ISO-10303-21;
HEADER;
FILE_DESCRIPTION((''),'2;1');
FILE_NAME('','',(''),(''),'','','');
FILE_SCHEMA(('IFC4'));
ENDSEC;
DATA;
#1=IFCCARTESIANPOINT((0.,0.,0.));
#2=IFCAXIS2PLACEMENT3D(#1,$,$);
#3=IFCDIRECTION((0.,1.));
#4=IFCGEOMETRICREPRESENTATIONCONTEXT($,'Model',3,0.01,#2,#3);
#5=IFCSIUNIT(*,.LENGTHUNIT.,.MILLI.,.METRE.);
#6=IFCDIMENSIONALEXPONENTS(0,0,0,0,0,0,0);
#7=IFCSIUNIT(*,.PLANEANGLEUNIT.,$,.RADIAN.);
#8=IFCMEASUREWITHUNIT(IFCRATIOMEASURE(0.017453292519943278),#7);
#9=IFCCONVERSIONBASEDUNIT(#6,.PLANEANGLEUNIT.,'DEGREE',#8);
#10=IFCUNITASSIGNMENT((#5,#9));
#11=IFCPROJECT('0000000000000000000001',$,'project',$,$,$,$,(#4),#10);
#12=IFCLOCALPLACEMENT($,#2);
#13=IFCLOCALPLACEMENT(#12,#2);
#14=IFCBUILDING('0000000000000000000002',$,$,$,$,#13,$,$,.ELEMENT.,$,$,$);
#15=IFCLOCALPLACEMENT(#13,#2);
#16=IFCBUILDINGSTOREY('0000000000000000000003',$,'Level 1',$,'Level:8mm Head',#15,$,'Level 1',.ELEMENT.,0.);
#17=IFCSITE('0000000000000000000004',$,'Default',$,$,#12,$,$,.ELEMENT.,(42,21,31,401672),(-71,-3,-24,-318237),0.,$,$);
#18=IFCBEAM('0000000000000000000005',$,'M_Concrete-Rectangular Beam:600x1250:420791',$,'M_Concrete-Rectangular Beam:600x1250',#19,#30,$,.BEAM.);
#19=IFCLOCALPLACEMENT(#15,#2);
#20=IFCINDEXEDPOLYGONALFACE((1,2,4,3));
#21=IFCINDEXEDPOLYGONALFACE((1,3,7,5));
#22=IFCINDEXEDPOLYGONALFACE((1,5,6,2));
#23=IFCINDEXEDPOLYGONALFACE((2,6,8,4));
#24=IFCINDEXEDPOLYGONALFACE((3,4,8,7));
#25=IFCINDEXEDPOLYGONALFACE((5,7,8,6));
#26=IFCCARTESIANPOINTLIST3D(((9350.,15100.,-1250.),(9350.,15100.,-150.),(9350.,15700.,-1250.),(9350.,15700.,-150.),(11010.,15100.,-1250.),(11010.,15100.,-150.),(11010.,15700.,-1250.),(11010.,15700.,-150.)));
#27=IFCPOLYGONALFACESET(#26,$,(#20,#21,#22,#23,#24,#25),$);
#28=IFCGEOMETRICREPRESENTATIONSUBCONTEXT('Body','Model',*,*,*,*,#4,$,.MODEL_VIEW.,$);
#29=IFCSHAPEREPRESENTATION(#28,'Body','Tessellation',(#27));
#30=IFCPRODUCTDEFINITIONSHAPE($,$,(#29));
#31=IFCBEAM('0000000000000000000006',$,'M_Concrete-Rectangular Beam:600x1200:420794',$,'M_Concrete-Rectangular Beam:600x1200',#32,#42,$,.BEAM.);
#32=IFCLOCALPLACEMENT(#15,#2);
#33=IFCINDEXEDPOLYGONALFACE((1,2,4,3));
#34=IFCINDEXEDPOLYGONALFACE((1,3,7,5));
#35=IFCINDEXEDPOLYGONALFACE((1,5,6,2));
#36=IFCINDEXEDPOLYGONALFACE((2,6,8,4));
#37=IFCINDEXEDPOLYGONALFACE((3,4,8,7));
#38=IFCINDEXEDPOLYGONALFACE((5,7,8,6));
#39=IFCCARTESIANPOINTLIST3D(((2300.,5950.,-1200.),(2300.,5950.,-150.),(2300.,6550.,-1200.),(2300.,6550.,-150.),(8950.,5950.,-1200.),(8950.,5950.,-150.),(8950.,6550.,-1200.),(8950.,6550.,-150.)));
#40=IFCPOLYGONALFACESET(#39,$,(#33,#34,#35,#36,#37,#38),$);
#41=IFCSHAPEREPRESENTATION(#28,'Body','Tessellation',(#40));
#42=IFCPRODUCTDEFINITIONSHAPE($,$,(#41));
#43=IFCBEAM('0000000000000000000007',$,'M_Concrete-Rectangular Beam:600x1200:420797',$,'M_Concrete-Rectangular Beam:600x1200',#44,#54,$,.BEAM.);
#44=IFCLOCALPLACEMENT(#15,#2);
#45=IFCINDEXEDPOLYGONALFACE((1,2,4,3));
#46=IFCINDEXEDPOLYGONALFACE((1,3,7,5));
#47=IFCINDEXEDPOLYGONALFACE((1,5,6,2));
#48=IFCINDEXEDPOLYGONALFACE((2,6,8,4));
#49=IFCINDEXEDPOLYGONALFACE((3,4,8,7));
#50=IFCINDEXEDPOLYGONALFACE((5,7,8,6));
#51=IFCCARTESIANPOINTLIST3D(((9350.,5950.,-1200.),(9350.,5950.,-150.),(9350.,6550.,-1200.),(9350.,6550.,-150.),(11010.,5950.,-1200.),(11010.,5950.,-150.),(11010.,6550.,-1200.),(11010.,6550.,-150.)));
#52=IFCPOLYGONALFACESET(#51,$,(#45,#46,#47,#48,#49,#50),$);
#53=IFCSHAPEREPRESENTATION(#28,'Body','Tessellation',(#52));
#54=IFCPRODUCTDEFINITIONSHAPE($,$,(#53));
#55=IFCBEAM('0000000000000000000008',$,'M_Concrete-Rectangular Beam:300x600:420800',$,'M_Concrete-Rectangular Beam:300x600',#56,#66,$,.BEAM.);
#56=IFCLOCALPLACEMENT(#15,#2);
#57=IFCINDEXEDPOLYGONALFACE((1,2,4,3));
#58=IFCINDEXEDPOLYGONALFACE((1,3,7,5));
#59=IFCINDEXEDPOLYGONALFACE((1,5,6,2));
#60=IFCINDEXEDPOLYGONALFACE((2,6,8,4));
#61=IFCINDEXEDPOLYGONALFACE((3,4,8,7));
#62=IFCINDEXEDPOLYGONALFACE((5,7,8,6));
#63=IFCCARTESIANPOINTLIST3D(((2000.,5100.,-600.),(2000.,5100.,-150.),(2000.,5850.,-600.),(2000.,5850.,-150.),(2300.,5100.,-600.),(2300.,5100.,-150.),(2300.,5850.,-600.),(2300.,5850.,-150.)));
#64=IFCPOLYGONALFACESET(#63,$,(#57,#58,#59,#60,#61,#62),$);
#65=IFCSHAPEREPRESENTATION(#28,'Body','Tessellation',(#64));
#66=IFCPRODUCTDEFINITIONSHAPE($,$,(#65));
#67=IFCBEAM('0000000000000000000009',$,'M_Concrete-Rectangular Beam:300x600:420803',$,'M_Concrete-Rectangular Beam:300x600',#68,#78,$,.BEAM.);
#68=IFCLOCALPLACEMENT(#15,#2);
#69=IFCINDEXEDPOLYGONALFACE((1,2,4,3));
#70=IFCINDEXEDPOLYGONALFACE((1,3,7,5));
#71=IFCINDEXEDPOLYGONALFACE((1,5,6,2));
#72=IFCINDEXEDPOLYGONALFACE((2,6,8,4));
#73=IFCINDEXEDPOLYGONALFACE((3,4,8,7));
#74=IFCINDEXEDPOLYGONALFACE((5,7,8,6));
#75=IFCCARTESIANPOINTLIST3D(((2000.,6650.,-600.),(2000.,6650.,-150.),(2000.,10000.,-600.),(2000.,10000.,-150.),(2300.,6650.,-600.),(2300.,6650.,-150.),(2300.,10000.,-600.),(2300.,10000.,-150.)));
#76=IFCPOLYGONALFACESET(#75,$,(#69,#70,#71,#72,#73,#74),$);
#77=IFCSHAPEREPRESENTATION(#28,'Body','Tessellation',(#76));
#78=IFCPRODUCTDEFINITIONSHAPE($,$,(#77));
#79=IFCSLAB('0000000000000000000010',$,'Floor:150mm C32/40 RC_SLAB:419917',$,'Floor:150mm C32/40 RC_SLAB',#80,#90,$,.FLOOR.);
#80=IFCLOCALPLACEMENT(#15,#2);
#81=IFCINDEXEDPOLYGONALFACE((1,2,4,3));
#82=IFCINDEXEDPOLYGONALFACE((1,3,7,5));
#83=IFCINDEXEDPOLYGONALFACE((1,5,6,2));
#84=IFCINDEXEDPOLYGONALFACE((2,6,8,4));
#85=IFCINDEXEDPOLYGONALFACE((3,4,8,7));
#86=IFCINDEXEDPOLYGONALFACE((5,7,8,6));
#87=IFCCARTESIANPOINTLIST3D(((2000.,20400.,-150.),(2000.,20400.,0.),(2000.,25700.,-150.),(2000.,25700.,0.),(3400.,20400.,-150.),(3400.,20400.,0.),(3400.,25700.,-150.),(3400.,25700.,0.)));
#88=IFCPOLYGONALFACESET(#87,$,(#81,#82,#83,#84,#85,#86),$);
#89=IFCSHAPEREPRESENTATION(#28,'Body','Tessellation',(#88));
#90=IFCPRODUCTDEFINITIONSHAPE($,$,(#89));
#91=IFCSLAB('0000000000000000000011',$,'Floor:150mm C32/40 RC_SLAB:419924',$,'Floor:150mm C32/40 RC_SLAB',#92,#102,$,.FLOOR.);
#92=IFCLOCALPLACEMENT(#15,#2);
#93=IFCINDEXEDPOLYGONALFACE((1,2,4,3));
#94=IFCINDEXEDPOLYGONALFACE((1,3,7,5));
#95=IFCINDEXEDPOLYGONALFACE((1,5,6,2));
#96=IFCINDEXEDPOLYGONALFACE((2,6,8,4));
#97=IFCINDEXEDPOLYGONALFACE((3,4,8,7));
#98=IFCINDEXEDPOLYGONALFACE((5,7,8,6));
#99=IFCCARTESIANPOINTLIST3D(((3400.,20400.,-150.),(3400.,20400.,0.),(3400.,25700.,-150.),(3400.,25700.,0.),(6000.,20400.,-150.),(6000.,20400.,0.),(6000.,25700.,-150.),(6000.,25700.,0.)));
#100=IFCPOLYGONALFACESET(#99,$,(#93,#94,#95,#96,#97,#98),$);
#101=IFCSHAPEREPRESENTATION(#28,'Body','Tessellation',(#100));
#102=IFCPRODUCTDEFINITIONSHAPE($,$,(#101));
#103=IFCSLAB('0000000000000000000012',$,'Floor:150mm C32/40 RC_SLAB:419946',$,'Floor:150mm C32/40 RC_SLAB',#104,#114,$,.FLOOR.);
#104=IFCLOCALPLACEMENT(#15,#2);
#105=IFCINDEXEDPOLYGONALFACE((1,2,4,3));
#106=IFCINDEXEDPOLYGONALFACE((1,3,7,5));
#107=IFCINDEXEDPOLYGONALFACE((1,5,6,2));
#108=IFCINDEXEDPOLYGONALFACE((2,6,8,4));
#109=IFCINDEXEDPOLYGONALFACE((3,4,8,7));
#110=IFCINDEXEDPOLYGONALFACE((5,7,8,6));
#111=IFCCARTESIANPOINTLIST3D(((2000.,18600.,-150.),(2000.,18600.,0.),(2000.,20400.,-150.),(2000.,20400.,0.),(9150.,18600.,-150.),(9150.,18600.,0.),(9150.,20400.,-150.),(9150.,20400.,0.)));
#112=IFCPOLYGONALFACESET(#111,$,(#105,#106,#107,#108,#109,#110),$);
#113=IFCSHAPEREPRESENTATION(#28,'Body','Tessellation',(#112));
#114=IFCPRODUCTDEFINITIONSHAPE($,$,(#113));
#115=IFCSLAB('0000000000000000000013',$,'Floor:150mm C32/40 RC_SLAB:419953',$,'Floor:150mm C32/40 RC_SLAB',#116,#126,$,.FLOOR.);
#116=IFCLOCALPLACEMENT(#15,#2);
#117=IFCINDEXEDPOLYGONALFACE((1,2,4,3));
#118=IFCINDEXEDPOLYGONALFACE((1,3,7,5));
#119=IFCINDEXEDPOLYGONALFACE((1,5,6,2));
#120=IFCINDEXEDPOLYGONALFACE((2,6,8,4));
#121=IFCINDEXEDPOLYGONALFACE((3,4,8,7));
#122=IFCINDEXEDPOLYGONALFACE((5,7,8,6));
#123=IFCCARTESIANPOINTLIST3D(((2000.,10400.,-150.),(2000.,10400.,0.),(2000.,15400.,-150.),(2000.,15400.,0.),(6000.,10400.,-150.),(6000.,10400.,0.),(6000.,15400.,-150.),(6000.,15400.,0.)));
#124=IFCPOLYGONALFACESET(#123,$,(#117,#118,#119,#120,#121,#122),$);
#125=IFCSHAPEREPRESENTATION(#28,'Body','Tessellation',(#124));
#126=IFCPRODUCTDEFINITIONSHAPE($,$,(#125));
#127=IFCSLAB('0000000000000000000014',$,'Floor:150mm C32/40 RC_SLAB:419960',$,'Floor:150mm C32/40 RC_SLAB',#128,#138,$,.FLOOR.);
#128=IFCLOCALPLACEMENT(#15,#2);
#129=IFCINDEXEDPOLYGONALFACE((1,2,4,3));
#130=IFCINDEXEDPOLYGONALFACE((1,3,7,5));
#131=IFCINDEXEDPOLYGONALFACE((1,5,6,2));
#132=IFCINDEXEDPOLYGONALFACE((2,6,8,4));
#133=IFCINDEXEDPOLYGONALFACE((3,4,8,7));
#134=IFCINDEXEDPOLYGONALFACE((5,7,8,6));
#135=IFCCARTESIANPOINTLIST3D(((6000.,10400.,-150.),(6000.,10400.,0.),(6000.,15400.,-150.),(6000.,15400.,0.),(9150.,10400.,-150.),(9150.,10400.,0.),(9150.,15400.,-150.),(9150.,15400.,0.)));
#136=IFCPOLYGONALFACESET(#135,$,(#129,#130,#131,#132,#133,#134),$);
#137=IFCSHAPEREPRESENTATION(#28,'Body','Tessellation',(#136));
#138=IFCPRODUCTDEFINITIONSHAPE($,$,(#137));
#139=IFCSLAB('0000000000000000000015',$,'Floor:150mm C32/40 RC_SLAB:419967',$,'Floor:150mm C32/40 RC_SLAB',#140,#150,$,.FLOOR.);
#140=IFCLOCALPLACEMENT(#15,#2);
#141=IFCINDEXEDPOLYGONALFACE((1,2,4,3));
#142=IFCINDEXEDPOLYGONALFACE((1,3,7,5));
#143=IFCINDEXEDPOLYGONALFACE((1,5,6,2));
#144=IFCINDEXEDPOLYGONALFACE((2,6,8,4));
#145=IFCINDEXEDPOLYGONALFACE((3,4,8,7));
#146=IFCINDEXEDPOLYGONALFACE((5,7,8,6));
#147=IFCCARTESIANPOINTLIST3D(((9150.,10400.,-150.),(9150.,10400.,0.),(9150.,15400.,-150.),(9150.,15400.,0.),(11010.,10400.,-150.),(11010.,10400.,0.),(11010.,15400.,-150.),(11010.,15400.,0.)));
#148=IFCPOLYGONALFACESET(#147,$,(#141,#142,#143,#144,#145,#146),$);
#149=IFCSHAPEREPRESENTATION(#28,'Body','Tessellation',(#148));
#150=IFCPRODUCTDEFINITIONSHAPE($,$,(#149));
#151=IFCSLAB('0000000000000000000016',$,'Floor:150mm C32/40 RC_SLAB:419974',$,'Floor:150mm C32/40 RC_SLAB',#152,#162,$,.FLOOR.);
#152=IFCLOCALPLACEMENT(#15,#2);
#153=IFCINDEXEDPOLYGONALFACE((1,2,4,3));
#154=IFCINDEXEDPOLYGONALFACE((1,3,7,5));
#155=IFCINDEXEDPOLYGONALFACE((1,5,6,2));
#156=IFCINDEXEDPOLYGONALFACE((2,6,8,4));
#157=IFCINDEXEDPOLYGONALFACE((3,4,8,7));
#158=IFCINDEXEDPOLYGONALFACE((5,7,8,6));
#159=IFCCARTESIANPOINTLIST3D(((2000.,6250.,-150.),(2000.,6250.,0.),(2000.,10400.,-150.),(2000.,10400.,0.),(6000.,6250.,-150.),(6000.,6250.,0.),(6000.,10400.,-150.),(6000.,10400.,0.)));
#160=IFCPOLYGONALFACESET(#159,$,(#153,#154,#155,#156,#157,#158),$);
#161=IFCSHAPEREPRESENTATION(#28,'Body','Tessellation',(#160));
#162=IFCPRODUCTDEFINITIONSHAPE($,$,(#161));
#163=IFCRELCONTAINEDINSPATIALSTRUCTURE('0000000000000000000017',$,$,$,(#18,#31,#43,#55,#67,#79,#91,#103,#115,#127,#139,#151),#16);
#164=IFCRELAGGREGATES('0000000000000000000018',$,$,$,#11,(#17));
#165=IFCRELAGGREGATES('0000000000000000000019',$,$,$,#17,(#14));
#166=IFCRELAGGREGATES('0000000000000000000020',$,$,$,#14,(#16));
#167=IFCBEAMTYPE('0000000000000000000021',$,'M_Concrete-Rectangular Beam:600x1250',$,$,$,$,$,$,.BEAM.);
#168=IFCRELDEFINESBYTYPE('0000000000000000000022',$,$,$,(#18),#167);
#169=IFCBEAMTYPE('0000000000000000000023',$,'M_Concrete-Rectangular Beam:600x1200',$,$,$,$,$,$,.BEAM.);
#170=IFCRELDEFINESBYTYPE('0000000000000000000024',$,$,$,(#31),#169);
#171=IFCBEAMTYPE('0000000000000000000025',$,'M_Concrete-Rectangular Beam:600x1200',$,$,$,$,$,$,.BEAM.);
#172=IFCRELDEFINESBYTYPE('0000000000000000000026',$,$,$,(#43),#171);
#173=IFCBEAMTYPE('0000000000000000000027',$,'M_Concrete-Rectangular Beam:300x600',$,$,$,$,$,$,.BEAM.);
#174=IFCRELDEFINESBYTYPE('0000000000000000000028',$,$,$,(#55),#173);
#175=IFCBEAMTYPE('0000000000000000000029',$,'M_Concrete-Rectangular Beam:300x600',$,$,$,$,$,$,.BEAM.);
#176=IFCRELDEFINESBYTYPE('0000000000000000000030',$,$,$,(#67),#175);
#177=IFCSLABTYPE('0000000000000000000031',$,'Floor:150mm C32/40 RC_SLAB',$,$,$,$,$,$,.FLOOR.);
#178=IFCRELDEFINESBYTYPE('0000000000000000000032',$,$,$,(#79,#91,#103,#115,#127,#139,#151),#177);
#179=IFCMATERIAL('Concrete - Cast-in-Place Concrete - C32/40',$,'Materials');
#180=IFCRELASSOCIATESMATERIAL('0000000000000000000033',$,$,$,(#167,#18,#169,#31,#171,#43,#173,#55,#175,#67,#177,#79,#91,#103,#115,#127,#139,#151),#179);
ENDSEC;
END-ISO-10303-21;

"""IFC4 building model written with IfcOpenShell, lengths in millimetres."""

from ifc_helpers import new_model, entity, si_unit, converted_unit, direction, frame, origin, place, context, subcontext, project, spatial, indexed_curve, outline, extrude, source, transform, mapped, material, type_object, type_shapes, element, save


model = new_model("IFC4")

# Units and contexts
model_context = context("Model", 3, precision=0.01, world=origin(), true_north=direction((0.0, 1.0)))
body_context = subcontext(model_context, "Body", "Model", "MODEL_VIEW")
ifc_project = project(units=[si_unit("LENGTHUNIT", "METRE", prefix="MILLI"), converted_unit("PLANEANGLEUNIT", "DEGREE", entity("IfcRatioMeasure", 0.017453292519943278), si_unit("PLANEANGLEUNIT", "RADIAN"), dimensions=[0, 0, 0, 0, 0, 0, 0])], contexts=[model_context])

# Site, building, storey
site_placement = place(None, origin())
site = spatial("IfcSite", under=ifc_project, at=site_placement, Name="Default", CompositionType="ELEMENT", RefLatitude=(42, 21, 31, 401672), RefLongitude=(-71, -3, -24, -318237), RefElevation=0.0)
building_placement = place(site_placement, origin())
building = spatial("IfcBuilding", under=site, at=building_placement, CompositionType="ELEMENT")
storey_placement = place(building_placement, origin())
storey = spatial("IfcBuildingStorey", under=building, at=storey_placement, Name="Level 1", ObjectType="Level:8mm Head", LongName="Level 1", CompositionType="ELEMENT", Elevation=0.0)

# Shared definitions
ifc_material = material(Name="Concrete - Cast-in-Place Concrete - C32/40", Category="Materials")

# Beams
beam_type_1 = type_object("IfcBeamType", Name="M_Concrete-Rectangular Beam:600x1250", PredefinedType="BEAM", material=ifc_material)
shared_shape_1 = source(origin(), body_context, "Body", "SweptSolid", [
    extrude(outline(indexed_curve([(-550.0, -300.0), (550.0, -300.0), (550.0, 300.0), (-550.0, 300.0), (-550.0, -300.0)], self_intersect=False)), frame((9350.0, 15400.0, -700.0), z_axis=(1.0, 0.0, 0.0), x_axis=(0.0, 0.0, -1.0)), (0.0, 0.0, 1.0), 1660.0),
])
type_shapes(beam_type_1, [shared_shape_1])
beam_1_placement = place(storey_placement, origin())
element("IfcBeam", 1, at=beam_1_placement, inside=storey, type_object=beam_type_1, material=ifc_material, Name="M_Concrete-Rectangular Beam:600x1250:420791", ObjectType="M_Concrete-Rectangular Beam:600x1250", PredefinedType="BEAM", context=body_context, shape_type="MappedRepresentation", body=[
    mapped(shared_shape_1, transform((0.0, 0.0, 0.0), scale=1.0)),
])
beam_type_2 = type_object("IfcBeamType", Name="M_Concrete-Rectangular Beam:600x1200", PredefinedType="BEAM", material=ifc_material)
shared_shape_2 = source(origin(), body_context, "Body", "SweptSolid", [
    extrude(outline(indexed_curve([(-525.0, -300.0), (525.0, -300.0), (525.0, 300.0), (-525.0, 300.0), (-525.0, -300.0)], self_intersect=False)), frame((2300.0, 6250.0, -675.0), z_axis=(1.0, 0.0, 0.0), x_axis=(0.0, 0.0, -1.0)), (0.0, 0.0, 1.0), 6650.0),
])
type_shapes(beam_type_2, [shared_shape_2])
beam_2_placement = place(storey_placement, origin())
element("IfcBeam", 2, at=beam_2_placement, inside=storey, type_object=beam_type_2, material=ifc_material, Name="M_Concrete-Rectangular Beam:600x1200:420794", ObjectType="M_Concrete-Rectangular Beam:600x1200", PredefinedType="BEAM", context=body_context, shape_type="MappedRepresentation", body=[
    mapped(shared_shape_2, transform((0.0, 0.0, 0.0), scale=1.0)),
])
beam_type_3 = type_object("IfcBeamType", Name="M_Concrete-Rectangular Beam:600x1200", PredefinedType="BEAM", material=ifc_material)
shared_shape_3 = source(origin(), body_context, "Body", "SweptSolid", [
    extrude(outline(indexed_curve([(-525.0, -300.0), (525.0, -300.0), (525.0, 300.0), (-525.0, 300.0), (-525.0, -300.0)], self_intersect=False)), frame((9350.0, 6250.0, -675.0), z_axis=(1.0, 0.0, 0.0), x_axis=(0.0, 0.0, -1.0)), (0.0, 0.0, 1.0), 1660.0),
])
type_shapes(beam_type_3, [shared_shape_3])
beam_3_placement = place(storey_placement, origin())
element("IfcBeam", 3, at=beam_3_placement, inside=storey, type_object=beam_type_3, material=ifc_material, Name="M_Concrete-Rectangular Beam:600x1200:420797", ObjectType="M_Concrete-Rectangular Beam:600x1200", PredefinedType="BEAM", context=body_context, shape_type="MappedRepresentation", body=[
    mapped(shared_shape_3, transform((0.0, 0.0, 0.0), scale=1.0)),
])
beam_type_4 = type_object("IfcBeamType", Name="M_Concrete-Rectangular Beam:300x600", PredefinedType="BEAM", material=ifc_material)
shared_shape_4 = source(origin(), body_context, "Body", "SweptSolid", [
    extrude(outline(indexed_curve([(-150.0, -225.0), (150.0, -225.0), (150.0, 225.0), (-150.0, 225.0), (-150.0, -225.0)], self_intersect=False)), frame((2150.0, 5100.0, -375.0), z_axis=(0.0, 1.0, 0.0), x_axis=(-1.0, 0.0, 0.0)), (0.0, 0.0, 1.0), 750.0),
])
type_shapes(beam_type_4, [shared_shape_4])
beam_4_placement = place(storey_placement, origin())
element("IfcBeam", 4, at=beam_4_placement, inside=storey, type_object=beam_type_4, material=ifc_material, Name="M_Concrete-Rectangular Beam:300x600:420800", ObjectType="M_Concrete-Rectangular Beam:300x600", PredefinedType="BEAM", context=body_context, shape_type="MappedRepresentation", body=[
    mapped(shared_shape_4, transform((0.0, 0.0, 0.0), scale=1.0)),
])
beam_type_5 = type_object("IfcBeamType", Name="M_Concrete-Rectangular Beam:300x600", PredefinedType="BEAM", material=ifc_material)
shared_shape_5 = source(origin(), body_context, "Body", "SweptSolid", [
    extrude(outline(indexed_curve([(-150.0, -225.0), (150.0, -225.0), (150.0, 225.0), (-150.0, 225.0), (-150.0, -225.0)], self_intersect=False)), frame((2150.0, 6650.0, -375.0), z_axis=(0.0, 1.0, 0.0), x_axis=(-1.0, 0.0, 0.0)), (0.0, 0.0, 1.0), 3350.0),
])
type_shapes(beam_type_5, [shared_shape_5])
beam_5_placement = place(storey_placement, origin())
element("IfcBeam", 5, at=beam_5_placement, inside=storey, type_object=beam_type_5, material=ifc_material, Name="M_Concrete-Rectangular Beam:300x600:420803", ObjectType="M_Concrete-Rectangular Beam:300x600", PredefinedType="BEAM", context=body_context, shape_type="MappedRepresentation", body=[
    mapped(shared_shape_5, transform((0.0, 0.0, 0.0), scale=1.0)),
])

# Slabs
slab_type = type_object("IfcSlabType", Name="Floor:150mm C32/40 RC_SLAB", PredefinedType="FLOOR", material=ifc_material)
slab_1_placement = place(storey_placement, origin())
element("IfcSlab", 6, at=slab_1_placement, inside=storey, type_object=slab_type, material=ifc_material, Name="Floor:150mm C32/40 RC_SLAB:419917", ObjectType="Floor:150mm C32/40 RC_SLAB", PredefinedType="FLOOR", context=body_context, shape_type="SweptSolid", body=[
    extrude(outline(indexed_curve([(-2650.0, -700.0), (2650.0, -700.0), (2650.0, 700.0), (-2650.0, 700.0), (-2650.0, -700.0)], self_intersect=False)), frame((2700.0, 23050.0, 0.0), z_axis=(0.0, 0.0, -1.0), x_axis=(0.0, 1.0, 0.0)), (0.0, 0.0, 1.0), 150.0),
])
slab_2_placement = place(storey_placement, origin())
element("IfcSlab", 7, at=slab_2_placement, inside=storey, type_object=slab_type, material=ifc_material, Name="Floor:150mm C32/40 RC_SLAB:419924", ObjectType="Floor:150mm C32/40 RC_SLAB", PredefinedType="FLOOR", context=body_context, shape_type="SweptSolid", body=[
    extrude(outline(indexed_curve([(-2650.0, -1300.0), (2650.0, -1300.0), (2650.0, 1300.0), (-2650.0, 1300.0), (-2650.0, -1300.0)], self_intersect=False)), frame((4700.0, 23050.0, 0.0), z_axis=(0.0, 0.0, -1.0), x_axis=(0.0, 1.0, 0.0)), (0.0, 0.0, 1.0), 150.0),
])
slab_3_placement = place(storey_placement, origin())
element("IfcSlab", 8, at=slab_3_placement, inside=storey, type_object=slab_type, material=ifc_material, Name="Floor:150mm C32/40 RC_SLAB:419946", ObjectType="Floor:150mm C32/40 RC_SLAB", PredefinedType="FLOOR", context=body_context, shape_type="SweptSolid", body=[
    extrude(outline(indexed_curve([(-900.0, -3575.0), (900.0, -3575.0), (900.0, 3575.0), (-900.0, 3575.0), (-900.0, -3575.0)], self_intersect=False)), frame((5575.0, 19500.0, 0.0), z_axis=(0.0, 0.0, -1.0), x_axis=(0.0, 1.0, 0.0)), (0.0, 0.0, 1.0), 150.0),
])
slab_4_placement = place(storey_placement, origin())
element("IfcSlab", 9, at=slab_4_placement, inside=storey, type_object=slab_type, material=ifc_material, Name="Floor:150mm C32/40 RC_SLAB:419953", ObjectType="Floor:150mm C32/40 RC_SLAB", PredefinedType="FLOOR", context=body_context, shape_type="SweptSolid", body=[
    extrude(outline(indexed_curve([(-2500.0, -2000.0), (2500.0, -2000.0), (2500.0, 2000.0), (-2500.0, 2000.0), (-2500.0, -2000.0)], self_intersect=False)), frame((4000.0, 12900.0, 0.0), z_axis=(0.0, 0.0, -1.0), x_axis=(0.0, 1.0, 0.0)), (0.0, 0.0, 1.0), 150.0),
])
slab_5_placement = place(storey_placement, origin())
element("IfcSlab", 10, at=slab_5_placement, inside=storey, type_object=slab_type, material=ifc_material, Name="Floor:150mm C32/40 RC_SLAB:419960", ObjectType="Floor:150mm C32/40 RC_SLAB", PredefinedType="FLOOR", context=body_context, shape_type="SweptSolid", body=[
    extrude(outline(indexed_curve([(-2500.0, -1575.0), (2500.0, -1575.0), (2500.0, 1575.0), (-2500.0, 1575.0), (-2500.0, -1575.0)], self_intersect=False)), frame((7575.0, 12900.0, 0.0), z_axis=(0.0, 0.0, -1.0), x_axis=(0.0, 1.0, 0.0)), (0.0, 0.0, 1.0), 150.0),
])
slab_6_placement = place(storey_placement, origin())
element("IfcSlab", 11, at=slab_6_placement, inside=storey, type_object=slab_type, material=ifc_material, Name="Floor:150mm C32/40 RC_SLAB:419967", ObjectType="Floor:150mm C32/40 RC_SLAB", PredefinedType="FLOOR", context=body_context, shape_type="SweptSolid", body=[
    extrude(outline(indexed_curve([(-2500.0, -930.0), (2500.0, -930.0), (2500.0, 930.0), (-2500.0, 930.0), (-2500.0, -930.0)], self_intersect=False)), frame((10080.0, 12900.0, 0.0), z_axis=(0.0, 0.0, -1.0), x_axis=(0.0, 1.0, 0.0)), (0.0, 0.0, 1.0), 150.0),
])
slab_7_placement = place(storey_placement, origin())
element("IfcSlab", 12, at=slab_7_placement, inside=storey, type_object=slab_type, material=ifc_material, Name="Floor:150mm C32/40 RC_SLAB:419974", ObjectType="Floor:150mm C32/40 RC_SLAB", PredefinedType="FLOOR", context=body_context, shape_type="SweptSolid", body=[
    extrude(outline(indexed_curve([(-2075.0, -2000.0), (2075.0, -2000.0), (2075.0, 2000.0), (-2075.0, 2000.0), (-2075.0, -2000.0)], self_intersect=False)), frame((4000.0, 8325.0, 0.0), z_axis=(0.0, 0.0, -1.0), x_axis=(0.0, 1.0, 0.0)), (0.0, 0.0, 1.0), 150.0),
])

save(model, "model.ifc")
